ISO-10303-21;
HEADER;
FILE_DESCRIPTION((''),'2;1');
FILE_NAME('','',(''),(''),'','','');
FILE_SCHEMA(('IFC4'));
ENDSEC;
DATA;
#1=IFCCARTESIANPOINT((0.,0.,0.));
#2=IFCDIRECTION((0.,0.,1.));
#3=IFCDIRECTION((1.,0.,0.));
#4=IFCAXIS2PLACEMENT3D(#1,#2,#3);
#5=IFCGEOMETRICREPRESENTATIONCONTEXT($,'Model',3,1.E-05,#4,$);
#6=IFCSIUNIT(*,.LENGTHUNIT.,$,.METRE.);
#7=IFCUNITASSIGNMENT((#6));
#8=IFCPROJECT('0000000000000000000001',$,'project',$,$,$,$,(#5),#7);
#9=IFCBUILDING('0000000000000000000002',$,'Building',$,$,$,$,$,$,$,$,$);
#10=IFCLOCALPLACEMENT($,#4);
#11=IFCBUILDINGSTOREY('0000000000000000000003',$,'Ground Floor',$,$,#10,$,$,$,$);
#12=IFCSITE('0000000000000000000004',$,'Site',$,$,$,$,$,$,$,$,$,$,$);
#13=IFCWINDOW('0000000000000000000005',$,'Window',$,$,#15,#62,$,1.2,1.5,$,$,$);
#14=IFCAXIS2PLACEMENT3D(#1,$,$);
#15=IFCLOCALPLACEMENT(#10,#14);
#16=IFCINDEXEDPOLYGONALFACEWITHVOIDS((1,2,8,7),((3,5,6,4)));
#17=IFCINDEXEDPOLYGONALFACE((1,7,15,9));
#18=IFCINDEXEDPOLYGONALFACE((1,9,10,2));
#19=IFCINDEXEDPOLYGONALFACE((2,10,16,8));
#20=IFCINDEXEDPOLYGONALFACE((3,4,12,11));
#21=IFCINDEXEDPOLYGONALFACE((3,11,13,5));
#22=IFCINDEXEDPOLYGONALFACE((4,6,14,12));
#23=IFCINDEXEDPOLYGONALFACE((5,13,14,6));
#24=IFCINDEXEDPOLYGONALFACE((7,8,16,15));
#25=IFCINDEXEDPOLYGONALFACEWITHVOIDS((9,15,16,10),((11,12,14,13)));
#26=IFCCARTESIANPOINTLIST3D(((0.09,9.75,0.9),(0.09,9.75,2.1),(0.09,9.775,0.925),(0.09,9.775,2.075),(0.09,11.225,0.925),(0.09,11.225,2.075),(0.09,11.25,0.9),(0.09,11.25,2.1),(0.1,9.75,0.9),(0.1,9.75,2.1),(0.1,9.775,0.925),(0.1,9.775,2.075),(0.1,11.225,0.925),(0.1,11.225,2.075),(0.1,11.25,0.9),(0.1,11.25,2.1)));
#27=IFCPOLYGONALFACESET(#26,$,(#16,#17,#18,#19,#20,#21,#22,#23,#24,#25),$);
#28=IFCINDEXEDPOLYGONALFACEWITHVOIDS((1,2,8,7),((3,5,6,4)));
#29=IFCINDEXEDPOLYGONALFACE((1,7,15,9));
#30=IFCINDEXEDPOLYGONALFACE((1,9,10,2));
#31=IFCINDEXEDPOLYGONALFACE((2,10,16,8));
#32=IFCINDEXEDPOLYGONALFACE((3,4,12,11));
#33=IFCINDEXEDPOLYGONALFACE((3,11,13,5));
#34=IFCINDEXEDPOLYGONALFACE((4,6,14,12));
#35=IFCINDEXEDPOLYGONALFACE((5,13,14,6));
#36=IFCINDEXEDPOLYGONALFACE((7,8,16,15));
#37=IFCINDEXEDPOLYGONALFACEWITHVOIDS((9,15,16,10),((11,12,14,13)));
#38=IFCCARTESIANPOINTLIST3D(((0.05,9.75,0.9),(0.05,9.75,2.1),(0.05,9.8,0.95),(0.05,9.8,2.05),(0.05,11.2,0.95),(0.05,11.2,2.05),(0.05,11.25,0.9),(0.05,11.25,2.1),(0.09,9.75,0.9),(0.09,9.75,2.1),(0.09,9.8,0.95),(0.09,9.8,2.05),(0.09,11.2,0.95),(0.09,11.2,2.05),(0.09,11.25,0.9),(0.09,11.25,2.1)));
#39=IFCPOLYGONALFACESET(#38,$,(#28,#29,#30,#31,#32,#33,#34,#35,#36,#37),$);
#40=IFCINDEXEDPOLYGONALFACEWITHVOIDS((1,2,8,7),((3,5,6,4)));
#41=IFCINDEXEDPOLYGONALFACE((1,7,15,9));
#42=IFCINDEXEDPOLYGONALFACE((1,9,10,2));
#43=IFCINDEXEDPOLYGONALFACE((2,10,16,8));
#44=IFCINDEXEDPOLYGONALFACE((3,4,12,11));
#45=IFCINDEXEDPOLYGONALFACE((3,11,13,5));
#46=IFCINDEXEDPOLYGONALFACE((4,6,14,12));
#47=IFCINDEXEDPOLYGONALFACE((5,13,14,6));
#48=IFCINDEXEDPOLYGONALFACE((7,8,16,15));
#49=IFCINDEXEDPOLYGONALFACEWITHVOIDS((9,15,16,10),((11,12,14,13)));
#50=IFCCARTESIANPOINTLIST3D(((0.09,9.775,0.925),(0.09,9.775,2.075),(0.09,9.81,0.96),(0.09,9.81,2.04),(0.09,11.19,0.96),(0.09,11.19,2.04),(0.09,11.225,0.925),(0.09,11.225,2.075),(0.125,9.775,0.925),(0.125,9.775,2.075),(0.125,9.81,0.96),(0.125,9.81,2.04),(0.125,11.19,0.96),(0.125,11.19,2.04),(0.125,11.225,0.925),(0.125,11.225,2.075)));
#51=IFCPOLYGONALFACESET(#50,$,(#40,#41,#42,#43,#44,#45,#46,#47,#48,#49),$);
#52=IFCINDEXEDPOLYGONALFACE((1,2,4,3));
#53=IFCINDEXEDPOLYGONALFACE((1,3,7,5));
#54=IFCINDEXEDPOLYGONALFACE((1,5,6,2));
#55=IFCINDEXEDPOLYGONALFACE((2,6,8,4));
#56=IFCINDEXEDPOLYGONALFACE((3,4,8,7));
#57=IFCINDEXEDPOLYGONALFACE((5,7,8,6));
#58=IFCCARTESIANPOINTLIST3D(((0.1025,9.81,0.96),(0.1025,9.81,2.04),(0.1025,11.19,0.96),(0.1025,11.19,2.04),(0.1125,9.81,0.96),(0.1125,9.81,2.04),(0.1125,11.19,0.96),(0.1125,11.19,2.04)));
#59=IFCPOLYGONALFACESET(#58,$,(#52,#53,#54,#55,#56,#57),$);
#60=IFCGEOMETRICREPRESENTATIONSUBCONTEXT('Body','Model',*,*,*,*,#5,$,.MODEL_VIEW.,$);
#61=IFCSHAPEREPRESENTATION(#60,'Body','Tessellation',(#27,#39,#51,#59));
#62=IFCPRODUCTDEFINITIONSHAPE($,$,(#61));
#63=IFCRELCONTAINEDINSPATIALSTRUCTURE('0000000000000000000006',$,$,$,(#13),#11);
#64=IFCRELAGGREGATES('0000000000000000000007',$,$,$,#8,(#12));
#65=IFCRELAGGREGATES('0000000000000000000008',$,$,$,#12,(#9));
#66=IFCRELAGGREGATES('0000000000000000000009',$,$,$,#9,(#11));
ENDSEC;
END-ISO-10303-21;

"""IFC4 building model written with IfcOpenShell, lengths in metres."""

from ifc_helpers import new_model, si_unit, frame, origin_with_axes, place, context, subcontext, project, spatial, line, indexed_curve, outline, extrude, element, save


model = new_model("IFC4")

# Units and contexts
model_context = context("Model", 3, precision=1e-05, world=origin_with_axes())
body_context = subcontext(model_context, "Body", "Model", "MODEL_VIEW")
ifc_project = project(units=[si_unit("LENGTHUNIT", "METRE")], contexts=[model_context])

# Site, building, storey
site = spatial("IfcSite", under=ifc_project, Name="Site")
building = spatial("IfcBuilding", under=site, Name="Building")
storey_placement = place(None, origin_with_axes())
storey = spatial("IfcBuildingStorey", under=building, at=storey_placement, Name="Ground Floor")

# Window
window_placement = place(storey_placement, frame((0.0, 11.25, 0.9), z_axis=(0.0, 0.0, 1.0), x_axis=(0.0, -1.0, 0.0)))
element("IfcWindow", 1, at=window_placement, inside=storey, Name="Window", OverallHeight=1.2, OverallWidth=1.5, context=body_context, shape_type="SweptSolid", body=[
    extrude(outline(indexed_curve([(0.0, 0.0), (1.5, 0.0), (1.5, 1.2), (0.0, 1.2)], segments=[line(1, 2, 3, 4, 1)]), holes=[indexed_curve([(0.025, 0.025), (1.475, 0.025), (1.475, 1.175), (0.025, 1.175)], segments=[line(1, 2, 3, 4, 1)])]), frame((0.0, 0.09, 0.0), z_axis=(0.0, -1.0, 0.0), x_axis=(1.0, 0.0, 0.0)), (0.0, 0.0, -1.0), 0.01),
    extrude(outline(indexed_curve([(0.0, 0.0), (1.5, 0.0), (1.5, 1.2), (0.0, 1.2)], segments=[line(1, 2, 3, 4, 1)]), holes=[indexed_curve([(0.05, 0.05), (1.45, 0.05), (1.45, 1.15), (0.05, 1.15)], segments=[line(1, 2, 3, 4, 1)])]), frame((0.0, 0.05, 0.0), z_axis=(0.0, -1.0, 0.0), x_axis=(1.0, 0.0, 0.0)), (0.0, 0.0, -1.0), 0.04),
    extrude(outline(indexed_curve([(0.0, 0.0), (1.45, 0.0), (1.45, 1.15), (0.0, 1.15)], segments=[line(1, 2, 3, 4, 1)]), holes=[indexed_curve([(0.035, 0.035), (1.415, 0.035), (1.415, 1.115), (0.035, 1.115)], segments=[line(1, 2, 3, 4, 1)])]), frame((0.025, 0.09, 0.025), z_axis=(0.0, -1.0, 0.0), x_axis=(1.0, 0.0, 0.0)), (0.0, 0.0, -1.0), 0.035),
    extrude(outline(indexed_curve([(0.035, 0.035), (1.415, 0.035), (1.415, 1.115), (0.035, 1.115)], segments=[line(1, 2, 3, 4, 1)])), frame((0.025, 0.1025, 0.025), z_axis=(0.0, -1.0, 0.0), x_axis=(1.0, 0.0, 0.0)), (0.0, 0.0, -1.0), 0.01),
])

save(model, "model.ifc")
